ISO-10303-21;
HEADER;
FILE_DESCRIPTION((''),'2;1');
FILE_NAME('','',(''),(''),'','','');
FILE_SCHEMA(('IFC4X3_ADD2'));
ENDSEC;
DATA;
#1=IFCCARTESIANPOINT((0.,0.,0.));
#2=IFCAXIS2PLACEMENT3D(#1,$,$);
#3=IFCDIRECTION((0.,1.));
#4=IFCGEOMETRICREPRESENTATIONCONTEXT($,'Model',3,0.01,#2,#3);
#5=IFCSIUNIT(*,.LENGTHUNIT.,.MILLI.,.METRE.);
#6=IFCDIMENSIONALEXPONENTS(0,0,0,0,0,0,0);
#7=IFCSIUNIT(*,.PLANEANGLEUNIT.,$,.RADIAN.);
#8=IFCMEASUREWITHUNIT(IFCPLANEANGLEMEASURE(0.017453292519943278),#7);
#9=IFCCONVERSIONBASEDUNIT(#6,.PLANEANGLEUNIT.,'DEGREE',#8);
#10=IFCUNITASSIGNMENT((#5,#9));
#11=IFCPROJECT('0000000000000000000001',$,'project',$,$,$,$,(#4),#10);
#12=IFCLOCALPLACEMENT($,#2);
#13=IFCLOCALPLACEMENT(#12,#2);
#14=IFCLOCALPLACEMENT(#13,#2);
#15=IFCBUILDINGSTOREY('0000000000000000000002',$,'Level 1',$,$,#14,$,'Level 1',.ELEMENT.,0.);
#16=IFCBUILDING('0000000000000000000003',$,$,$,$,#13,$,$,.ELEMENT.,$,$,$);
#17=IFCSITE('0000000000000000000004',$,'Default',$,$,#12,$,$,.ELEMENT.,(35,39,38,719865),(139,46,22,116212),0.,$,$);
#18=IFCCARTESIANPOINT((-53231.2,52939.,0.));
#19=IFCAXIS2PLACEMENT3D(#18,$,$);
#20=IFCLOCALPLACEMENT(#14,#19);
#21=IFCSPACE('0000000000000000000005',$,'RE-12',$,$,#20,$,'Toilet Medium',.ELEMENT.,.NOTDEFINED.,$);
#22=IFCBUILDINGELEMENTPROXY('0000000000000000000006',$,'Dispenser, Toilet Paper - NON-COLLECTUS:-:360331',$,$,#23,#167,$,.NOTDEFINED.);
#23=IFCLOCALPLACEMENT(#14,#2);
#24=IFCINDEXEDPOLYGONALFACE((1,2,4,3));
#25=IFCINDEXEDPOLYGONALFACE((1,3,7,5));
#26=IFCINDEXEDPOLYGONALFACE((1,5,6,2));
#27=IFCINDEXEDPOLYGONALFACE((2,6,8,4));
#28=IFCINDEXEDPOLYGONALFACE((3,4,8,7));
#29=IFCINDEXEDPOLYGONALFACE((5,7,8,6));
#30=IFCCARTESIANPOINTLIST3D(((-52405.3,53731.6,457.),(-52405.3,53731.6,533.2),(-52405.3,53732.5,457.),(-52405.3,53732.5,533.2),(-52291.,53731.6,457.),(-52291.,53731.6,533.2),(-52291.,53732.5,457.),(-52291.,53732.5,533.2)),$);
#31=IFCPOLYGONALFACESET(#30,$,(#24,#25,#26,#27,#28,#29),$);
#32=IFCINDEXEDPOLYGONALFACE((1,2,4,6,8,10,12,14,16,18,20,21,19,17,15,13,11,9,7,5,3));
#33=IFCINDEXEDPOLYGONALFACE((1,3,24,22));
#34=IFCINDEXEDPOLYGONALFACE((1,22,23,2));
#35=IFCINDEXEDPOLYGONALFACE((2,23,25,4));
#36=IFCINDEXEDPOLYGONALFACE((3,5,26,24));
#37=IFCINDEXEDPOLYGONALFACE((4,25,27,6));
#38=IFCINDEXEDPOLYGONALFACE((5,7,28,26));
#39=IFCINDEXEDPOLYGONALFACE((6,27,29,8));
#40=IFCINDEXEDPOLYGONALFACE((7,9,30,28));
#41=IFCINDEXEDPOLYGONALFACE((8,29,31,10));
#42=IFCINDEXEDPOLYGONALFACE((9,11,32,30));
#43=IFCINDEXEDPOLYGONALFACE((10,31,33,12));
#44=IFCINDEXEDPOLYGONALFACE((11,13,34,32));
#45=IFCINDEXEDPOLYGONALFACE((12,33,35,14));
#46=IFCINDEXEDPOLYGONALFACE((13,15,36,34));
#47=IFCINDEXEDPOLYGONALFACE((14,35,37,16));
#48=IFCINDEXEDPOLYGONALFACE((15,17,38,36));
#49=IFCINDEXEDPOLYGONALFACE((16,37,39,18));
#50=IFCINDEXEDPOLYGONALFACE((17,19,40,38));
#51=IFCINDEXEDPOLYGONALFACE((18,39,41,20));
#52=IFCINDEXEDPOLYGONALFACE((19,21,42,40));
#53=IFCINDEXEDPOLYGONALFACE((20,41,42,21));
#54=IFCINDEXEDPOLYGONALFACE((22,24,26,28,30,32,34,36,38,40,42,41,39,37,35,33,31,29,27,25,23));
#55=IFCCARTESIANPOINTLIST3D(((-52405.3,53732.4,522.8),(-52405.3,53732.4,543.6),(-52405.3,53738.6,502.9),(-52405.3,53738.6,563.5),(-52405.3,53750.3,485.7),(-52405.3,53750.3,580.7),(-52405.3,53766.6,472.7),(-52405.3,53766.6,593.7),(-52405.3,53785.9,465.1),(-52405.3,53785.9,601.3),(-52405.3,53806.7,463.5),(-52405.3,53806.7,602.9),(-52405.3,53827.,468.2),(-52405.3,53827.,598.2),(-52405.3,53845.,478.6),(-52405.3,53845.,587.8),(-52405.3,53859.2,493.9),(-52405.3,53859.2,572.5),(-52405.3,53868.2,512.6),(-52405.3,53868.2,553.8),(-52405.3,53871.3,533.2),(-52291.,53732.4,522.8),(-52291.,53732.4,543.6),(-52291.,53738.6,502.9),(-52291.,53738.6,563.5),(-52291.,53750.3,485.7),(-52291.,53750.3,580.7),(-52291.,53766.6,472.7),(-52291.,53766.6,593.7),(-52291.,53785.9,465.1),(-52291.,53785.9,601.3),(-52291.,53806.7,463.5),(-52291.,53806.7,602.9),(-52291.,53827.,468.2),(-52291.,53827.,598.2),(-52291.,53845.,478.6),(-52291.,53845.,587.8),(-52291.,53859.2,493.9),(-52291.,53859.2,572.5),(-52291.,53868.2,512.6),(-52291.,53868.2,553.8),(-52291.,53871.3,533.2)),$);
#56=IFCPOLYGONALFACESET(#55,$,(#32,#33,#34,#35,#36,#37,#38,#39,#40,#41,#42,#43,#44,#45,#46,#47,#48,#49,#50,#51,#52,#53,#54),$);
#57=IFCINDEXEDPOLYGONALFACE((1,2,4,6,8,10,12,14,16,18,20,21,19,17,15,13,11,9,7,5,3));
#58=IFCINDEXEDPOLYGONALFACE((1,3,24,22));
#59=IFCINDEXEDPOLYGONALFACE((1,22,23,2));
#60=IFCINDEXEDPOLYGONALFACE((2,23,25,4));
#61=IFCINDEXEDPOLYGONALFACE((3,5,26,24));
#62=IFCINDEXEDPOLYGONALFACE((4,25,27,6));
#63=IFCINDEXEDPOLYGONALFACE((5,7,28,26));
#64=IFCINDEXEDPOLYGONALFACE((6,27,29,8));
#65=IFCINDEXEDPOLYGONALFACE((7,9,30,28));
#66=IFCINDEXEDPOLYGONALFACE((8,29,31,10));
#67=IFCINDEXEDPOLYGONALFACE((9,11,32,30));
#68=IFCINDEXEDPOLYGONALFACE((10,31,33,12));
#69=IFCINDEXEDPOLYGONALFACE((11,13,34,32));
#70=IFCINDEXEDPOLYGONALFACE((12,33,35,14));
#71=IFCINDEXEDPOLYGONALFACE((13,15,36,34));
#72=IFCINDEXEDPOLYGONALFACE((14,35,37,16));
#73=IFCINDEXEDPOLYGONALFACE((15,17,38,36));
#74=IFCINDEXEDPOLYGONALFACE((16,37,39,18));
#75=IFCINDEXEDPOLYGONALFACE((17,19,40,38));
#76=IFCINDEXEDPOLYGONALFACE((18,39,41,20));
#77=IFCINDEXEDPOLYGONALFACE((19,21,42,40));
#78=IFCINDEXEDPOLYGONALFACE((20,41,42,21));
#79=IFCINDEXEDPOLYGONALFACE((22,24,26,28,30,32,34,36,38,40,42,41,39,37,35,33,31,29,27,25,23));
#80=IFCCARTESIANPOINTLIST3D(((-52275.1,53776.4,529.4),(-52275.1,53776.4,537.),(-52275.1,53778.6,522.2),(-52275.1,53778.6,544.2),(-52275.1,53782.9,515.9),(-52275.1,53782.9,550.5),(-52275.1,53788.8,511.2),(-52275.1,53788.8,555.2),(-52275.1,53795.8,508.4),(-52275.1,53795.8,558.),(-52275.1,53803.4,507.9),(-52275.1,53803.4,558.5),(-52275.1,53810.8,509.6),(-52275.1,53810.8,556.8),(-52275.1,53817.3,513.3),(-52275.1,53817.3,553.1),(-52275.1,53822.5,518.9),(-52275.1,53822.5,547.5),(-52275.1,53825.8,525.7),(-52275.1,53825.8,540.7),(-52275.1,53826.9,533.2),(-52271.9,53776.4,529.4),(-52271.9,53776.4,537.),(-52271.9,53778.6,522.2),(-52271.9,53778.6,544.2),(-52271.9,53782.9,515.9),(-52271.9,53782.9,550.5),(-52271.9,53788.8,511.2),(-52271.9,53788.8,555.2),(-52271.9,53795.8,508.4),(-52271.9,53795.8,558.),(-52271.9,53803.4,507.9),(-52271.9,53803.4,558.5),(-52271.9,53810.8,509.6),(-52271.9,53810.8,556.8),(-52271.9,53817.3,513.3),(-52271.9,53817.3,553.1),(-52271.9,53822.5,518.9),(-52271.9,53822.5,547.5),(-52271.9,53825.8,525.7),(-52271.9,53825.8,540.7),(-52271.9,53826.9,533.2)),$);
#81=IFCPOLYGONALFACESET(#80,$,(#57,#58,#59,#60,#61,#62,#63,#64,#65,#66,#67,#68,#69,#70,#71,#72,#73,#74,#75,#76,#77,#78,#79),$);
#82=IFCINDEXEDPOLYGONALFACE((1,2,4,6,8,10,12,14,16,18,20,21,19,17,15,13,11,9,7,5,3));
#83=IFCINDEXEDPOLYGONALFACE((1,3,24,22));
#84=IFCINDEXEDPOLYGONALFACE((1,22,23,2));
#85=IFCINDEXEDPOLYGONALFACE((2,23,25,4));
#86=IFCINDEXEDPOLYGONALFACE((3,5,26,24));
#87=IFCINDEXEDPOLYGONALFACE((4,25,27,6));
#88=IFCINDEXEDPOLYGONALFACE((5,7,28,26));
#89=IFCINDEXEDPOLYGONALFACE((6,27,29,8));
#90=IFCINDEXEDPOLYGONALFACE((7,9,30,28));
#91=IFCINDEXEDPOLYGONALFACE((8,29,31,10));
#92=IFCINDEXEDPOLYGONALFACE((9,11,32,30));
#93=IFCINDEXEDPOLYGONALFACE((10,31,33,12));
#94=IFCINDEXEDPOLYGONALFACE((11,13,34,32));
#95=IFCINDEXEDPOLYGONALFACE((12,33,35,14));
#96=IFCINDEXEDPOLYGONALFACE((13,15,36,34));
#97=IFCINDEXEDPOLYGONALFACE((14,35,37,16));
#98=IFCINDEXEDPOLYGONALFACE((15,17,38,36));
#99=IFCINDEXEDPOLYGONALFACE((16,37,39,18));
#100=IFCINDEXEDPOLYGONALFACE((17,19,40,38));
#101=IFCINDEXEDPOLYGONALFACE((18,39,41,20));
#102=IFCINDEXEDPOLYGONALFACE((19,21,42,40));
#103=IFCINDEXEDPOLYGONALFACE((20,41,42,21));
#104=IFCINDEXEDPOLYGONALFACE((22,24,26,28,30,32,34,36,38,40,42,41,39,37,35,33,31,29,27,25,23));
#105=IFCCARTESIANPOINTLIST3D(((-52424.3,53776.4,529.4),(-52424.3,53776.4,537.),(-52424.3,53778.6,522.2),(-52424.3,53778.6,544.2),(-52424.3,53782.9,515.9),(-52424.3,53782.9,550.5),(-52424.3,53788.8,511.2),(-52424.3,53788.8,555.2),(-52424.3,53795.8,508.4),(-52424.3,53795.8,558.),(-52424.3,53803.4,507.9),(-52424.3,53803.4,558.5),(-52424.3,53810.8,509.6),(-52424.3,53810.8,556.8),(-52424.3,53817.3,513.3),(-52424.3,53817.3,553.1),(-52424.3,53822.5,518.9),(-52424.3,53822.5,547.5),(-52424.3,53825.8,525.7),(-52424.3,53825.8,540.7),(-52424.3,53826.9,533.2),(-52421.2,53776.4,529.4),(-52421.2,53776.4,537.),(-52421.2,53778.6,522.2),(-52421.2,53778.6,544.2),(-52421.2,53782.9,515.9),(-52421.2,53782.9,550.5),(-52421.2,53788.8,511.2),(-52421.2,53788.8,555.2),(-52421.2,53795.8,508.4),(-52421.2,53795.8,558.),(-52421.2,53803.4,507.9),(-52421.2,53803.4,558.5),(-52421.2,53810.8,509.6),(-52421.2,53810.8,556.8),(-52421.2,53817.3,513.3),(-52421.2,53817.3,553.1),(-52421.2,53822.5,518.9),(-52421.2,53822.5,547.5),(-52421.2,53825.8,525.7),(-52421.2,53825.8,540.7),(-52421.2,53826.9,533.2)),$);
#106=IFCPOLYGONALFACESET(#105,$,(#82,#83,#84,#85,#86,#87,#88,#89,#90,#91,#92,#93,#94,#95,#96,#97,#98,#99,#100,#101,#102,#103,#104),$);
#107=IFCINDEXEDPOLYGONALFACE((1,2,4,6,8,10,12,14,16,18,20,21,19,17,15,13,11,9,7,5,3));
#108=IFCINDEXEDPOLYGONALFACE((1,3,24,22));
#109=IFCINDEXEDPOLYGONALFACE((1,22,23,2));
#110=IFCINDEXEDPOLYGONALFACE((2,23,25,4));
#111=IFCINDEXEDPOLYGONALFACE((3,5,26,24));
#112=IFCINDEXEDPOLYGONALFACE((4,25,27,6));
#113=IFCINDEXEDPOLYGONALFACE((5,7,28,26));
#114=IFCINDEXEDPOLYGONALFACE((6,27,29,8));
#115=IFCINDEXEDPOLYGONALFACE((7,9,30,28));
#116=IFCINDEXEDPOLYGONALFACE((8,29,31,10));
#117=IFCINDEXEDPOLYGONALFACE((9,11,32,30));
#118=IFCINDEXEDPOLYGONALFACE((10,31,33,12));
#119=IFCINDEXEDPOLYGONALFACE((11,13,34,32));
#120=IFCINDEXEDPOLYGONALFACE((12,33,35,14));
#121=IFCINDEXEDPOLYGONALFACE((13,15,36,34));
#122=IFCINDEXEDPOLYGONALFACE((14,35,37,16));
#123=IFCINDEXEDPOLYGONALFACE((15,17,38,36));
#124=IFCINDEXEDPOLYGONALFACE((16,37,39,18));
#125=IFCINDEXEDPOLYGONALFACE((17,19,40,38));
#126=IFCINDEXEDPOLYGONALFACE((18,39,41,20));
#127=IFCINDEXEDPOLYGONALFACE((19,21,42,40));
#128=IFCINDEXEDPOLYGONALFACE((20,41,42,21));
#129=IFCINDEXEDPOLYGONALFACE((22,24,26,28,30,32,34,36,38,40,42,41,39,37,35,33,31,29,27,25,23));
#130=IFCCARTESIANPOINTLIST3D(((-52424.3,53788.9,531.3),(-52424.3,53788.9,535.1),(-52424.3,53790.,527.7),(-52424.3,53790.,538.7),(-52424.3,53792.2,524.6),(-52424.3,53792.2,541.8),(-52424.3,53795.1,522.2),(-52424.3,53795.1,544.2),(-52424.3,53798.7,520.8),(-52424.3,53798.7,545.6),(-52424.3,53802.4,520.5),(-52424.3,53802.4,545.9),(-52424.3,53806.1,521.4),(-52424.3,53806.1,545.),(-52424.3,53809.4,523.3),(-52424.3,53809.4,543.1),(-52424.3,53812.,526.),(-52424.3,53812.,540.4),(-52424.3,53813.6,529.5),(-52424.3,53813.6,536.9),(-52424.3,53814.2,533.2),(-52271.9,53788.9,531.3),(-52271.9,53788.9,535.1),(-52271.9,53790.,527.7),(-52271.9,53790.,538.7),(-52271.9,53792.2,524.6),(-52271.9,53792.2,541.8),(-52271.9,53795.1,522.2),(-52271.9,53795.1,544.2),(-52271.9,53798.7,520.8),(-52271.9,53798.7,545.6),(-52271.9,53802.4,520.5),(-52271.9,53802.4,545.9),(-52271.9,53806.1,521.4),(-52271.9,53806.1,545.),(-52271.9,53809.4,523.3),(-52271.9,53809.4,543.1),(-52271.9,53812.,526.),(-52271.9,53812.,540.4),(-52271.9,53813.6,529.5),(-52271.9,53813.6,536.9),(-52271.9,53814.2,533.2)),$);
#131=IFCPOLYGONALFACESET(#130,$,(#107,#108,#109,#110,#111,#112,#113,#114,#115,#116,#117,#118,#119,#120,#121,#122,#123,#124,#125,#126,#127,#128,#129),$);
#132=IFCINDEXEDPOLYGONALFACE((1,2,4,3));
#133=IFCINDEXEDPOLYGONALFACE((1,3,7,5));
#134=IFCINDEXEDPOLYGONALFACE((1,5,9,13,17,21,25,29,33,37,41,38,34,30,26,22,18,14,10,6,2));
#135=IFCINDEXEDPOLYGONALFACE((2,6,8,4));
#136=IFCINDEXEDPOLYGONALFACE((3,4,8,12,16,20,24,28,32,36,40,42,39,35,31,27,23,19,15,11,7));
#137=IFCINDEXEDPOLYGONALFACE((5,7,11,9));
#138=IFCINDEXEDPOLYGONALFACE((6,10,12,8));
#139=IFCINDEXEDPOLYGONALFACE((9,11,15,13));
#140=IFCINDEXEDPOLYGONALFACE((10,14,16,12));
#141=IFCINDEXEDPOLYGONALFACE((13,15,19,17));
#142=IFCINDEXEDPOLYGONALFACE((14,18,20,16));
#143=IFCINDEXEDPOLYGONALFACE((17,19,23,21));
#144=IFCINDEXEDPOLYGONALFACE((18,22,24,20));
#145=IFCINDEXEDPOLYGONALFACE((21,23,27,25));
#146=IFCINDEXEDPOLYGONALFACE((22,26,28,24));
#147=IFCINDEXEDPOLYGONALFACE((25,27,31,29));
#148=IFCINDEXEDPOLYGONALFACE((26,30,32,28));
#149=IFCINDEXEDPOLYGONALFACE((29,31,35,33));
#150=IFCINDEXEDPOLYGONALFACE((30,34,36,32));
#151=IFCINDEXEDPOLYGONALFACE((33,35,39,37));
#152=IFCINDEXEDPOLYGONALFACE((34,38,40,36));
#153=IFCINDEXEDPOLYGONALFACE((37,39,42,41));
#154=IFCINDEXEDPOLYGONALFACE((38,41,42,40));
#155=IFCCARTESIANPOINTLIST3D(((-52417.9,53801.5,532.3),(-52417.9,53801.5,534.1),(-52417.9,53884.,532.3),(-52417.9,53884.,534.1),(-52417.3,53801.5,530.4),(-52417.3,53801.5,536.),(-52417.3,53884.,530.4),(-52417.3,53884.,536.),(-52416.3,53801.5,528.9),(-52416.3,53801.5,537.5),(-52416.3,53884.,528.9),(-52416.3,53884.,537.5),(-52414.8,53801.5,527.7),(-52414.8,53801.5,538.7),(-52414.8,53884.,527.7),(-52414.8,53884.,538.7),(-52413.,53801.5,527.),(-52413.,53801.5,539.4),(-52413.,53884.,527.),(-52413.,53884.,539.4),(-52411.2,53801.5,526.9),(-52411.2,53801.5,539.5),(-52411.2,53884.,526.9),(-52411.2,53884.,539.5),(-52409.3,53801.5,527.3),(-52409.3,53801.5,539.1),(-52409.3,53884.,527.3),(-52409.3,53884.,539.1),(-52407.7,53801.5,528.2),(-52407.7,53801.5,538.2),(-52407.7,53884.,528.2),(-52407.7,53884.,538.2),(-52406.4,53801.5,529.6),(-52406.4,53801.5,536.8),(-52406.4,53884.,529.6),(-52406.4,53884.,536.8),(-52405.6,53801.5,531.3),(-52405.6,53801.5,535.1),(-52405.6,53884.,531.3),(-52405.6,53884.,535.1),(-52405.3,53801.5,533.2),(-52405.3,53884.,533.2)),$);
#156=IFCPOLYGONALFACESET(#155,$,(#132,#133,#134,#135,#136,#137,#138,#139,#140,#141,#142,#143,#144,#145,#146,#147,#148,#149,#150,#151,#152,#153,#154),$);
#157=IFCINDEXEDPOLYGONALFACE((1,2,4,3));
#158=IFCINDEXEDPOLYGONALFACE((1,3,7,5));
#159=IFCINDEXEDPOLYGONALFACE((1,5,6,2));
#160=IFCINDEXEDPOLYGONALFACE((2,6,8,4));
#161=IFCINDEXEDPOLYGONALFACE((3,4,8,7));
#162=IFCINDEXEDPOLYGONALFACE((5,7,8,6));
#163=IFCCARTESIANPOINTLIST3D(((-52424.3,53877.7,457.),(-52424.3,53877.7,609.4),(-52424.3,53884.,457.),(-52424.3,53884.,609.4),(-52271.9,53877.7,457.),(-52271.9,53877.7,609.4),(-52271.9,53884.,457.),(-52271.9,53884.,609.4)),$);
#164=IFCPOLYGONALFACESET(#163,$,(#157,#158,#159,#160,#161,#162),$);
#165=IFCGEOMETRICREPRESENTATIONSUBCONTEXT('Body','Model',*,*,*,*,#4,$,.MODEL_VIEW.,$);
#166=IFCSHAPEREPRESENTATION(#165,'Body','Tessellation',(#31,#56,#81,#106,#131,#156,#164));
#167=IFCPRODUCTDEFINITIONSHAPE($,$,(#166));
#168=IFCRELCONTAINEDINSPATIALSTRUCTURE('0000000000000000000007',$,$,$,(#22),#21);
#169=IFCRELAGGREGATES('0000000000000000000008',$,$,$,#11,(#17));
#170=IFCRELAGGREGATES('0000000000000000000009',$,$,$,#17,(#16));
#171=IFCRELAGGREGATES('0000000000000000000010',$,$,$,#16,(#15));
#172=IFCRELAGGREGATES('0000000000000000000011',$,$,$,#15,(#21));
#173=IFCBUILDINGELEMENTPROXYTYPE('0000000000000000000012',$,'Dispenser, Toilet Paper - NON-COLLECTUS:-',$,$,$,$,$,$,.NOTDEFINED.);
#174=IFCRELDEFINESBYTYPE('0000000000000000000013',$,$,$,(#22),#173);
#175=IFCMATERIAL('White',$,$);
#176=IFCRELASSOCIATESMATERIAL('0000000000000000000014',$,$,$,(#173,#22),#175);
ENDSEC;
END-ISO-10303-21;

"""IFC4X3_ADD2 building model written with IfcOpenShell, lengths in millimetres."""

from ifc_helpers import new_model, entity, si_unit, converted_unit, direction, frame, frame_2d, origin, origin_2d_with_axis, place, context, subcontext, project, spatial, rectangle, circle, extrude, source, transform, mapped, material, type_object, type_shapes, element, save


model = new_model("IFC4X3_ADD2")

# Units and contexts
model_context = context("Model", 3, precision=0.01, world=origin(), true_north=direction((0.0, 1.0)))
body_context = subcontext(model_context, "Body", "Model", "MODEL_VIEW")
ifc_project = project(units=[si_unit("LENGTHUNIT", "METRE", prefix="MILLI"), converted_unit("PLANEANGLEUNIT", "DEGREE", entity("IfcPlaneAngleMeasure", 0.017453292519943278), si_unit("PLANEANGLEUNIT", "RADIAN"), dimensions=[0, 0, 0, 0, 0, 0, 0])], contexts=[model_context])

# Site, building, storey
site_placement = place(None, origin())
site = spatial("IfcSite", under=ifc_project, at=site_placement, Name="Default", CompositionType="ELEMENT", RefLatitude=(35, 39, 38, 719865), RefLongitude=(139, 46, 22, 116212), RefElevation=0.0)
building_placement = place(site_placement, origin())
building = spatial("IfcBuilding", under=site, at=building_placement, CompositionType="ELEMENT")
storey_placement = place(building_placement, origin())
storey = spatial("IfcBuildingStorey", under=building, at=storey_placement, Name="Level 1", LongName="Level 1", CompositionType="ELEMENT", Elevation=0.0)

# Shared definitions
ifc_material_1 = material(Name="White")

# Shared definitions
space_1_placement = place(storey_placement, frame((-53231.2, 52939.0, 0.0)))
space_1 = spatial("IfcSpace", under=storey, at=space_1_placement, Name="RE-12", LongName="Toilet Medium", CompositionType="ELEMENT", PredefinedType="NOTDEFINED")

# Building element proxy
building_element_proxy_type_1 = type_object("IfcBuildingElementProxyType", Name="Dispenser, Toilet Paper - NON-COLLECTUS:-", PredefinedType="NOTDEFINED", material=ifc_material_1)
shared_shape_1 = source(origin(), body_context, "Body", "SweptSolid", [
    extrude(rectangle(XDim=114.3, YDim=0.9, at=origin_2d_with_axis()), frame((0.0, -152.0, 0.0), z_axis=(0.0, 0.0, 1.0), x_axis=(-1.0, 0.0, 0.0)), (0.0, 0.0, 1.0), 76.2),
    extrude(circle(Radius=69.9, at=frame_2d((0.0, 0.0), x_axis=(1.0, 0.0))), frame((-57.2, -82.5, 76.2), z_axis=(1.0, 0.0, 0.0), x_axis=(0.0, 1.0, 0.0)), (0.0, 0.0, 1.0), 114.3),
    extrude(circle(Radius=25.4, at=frame_2d((0.0, 0.0), x_axis=(1.0, 0.0))), frame((73.0, -82.5, 76.2), z_axis=(1.0, 0.0, 0.0), x_axis=(0.0, 1.0, 0.0)), (0.0, 0.0, 1.0), 3.2),
    extrude(circle(Radius=25.4, at=frame_2d((0.0, 0.0), x_axis=(1.0, 0.0))), frame((-76.2, -82.5, 76.2), z_axis=(1.0, 0.0, 0.0), x_axis=(0.0, 1.0, 0.0)), (0.0, 0.0, 1.0), 3.2),
    extrude(circle(Radius=12.7, at=frame_2d((0.0, 0.0), x_axis=(1.0, 0.0))), frame((-76.2, -82.5, 76.2), z_axis=(1.0, 0.0, 0.0), x_axis=(0.0, 1.0, 0.0)), (0.0, 0.0, 1.0), 152.4),
    extrude(circle(Radius=6.4, at=frame_2d((0.0, 0.0), x_axis=(1.0, 0.0))), frame((-63.5, -82.5, 76.2), z_axis=(0.0, 1.0, 0.0), x_axis=(1.0, 0.0, 0.0)), (0.0, 0.0, 1.0), 82.5),
    extrude(rectangle(XDim=6.4, YDim=152.4, at=origin_2d_with_axis()), frame((0.0, -3.2, 0.0), z_axis=(0.0, 0.0, 1.0), x_axis=(0.0, 1.0, 0.0)), (0.0, 0.0, 1.0), 152.4),
])
type_shapes(building_element_proxy_type_1, [shared_shape_1])
proxy_1_placement = place(space_1_placement, frame((883.1, 945.0, 457.0)))
element("IfcBuildingElementProxy", 1, at=proxy_1_placement, inside=space_1, type_object=building_element_proxy_type_1, material=ifc_material_1, Name="Dispenser, Toilet Paper - NON-COLLECTUS:-:360331", PredefinedType="NOTDEFINED", context=body_context, shape_type="MappedRepresentation", body=[
    mapped(shared_shape_1, transform((0.0, 0.0, 0.0), scale=1.0)),
])

save(model, "model.ifc")
